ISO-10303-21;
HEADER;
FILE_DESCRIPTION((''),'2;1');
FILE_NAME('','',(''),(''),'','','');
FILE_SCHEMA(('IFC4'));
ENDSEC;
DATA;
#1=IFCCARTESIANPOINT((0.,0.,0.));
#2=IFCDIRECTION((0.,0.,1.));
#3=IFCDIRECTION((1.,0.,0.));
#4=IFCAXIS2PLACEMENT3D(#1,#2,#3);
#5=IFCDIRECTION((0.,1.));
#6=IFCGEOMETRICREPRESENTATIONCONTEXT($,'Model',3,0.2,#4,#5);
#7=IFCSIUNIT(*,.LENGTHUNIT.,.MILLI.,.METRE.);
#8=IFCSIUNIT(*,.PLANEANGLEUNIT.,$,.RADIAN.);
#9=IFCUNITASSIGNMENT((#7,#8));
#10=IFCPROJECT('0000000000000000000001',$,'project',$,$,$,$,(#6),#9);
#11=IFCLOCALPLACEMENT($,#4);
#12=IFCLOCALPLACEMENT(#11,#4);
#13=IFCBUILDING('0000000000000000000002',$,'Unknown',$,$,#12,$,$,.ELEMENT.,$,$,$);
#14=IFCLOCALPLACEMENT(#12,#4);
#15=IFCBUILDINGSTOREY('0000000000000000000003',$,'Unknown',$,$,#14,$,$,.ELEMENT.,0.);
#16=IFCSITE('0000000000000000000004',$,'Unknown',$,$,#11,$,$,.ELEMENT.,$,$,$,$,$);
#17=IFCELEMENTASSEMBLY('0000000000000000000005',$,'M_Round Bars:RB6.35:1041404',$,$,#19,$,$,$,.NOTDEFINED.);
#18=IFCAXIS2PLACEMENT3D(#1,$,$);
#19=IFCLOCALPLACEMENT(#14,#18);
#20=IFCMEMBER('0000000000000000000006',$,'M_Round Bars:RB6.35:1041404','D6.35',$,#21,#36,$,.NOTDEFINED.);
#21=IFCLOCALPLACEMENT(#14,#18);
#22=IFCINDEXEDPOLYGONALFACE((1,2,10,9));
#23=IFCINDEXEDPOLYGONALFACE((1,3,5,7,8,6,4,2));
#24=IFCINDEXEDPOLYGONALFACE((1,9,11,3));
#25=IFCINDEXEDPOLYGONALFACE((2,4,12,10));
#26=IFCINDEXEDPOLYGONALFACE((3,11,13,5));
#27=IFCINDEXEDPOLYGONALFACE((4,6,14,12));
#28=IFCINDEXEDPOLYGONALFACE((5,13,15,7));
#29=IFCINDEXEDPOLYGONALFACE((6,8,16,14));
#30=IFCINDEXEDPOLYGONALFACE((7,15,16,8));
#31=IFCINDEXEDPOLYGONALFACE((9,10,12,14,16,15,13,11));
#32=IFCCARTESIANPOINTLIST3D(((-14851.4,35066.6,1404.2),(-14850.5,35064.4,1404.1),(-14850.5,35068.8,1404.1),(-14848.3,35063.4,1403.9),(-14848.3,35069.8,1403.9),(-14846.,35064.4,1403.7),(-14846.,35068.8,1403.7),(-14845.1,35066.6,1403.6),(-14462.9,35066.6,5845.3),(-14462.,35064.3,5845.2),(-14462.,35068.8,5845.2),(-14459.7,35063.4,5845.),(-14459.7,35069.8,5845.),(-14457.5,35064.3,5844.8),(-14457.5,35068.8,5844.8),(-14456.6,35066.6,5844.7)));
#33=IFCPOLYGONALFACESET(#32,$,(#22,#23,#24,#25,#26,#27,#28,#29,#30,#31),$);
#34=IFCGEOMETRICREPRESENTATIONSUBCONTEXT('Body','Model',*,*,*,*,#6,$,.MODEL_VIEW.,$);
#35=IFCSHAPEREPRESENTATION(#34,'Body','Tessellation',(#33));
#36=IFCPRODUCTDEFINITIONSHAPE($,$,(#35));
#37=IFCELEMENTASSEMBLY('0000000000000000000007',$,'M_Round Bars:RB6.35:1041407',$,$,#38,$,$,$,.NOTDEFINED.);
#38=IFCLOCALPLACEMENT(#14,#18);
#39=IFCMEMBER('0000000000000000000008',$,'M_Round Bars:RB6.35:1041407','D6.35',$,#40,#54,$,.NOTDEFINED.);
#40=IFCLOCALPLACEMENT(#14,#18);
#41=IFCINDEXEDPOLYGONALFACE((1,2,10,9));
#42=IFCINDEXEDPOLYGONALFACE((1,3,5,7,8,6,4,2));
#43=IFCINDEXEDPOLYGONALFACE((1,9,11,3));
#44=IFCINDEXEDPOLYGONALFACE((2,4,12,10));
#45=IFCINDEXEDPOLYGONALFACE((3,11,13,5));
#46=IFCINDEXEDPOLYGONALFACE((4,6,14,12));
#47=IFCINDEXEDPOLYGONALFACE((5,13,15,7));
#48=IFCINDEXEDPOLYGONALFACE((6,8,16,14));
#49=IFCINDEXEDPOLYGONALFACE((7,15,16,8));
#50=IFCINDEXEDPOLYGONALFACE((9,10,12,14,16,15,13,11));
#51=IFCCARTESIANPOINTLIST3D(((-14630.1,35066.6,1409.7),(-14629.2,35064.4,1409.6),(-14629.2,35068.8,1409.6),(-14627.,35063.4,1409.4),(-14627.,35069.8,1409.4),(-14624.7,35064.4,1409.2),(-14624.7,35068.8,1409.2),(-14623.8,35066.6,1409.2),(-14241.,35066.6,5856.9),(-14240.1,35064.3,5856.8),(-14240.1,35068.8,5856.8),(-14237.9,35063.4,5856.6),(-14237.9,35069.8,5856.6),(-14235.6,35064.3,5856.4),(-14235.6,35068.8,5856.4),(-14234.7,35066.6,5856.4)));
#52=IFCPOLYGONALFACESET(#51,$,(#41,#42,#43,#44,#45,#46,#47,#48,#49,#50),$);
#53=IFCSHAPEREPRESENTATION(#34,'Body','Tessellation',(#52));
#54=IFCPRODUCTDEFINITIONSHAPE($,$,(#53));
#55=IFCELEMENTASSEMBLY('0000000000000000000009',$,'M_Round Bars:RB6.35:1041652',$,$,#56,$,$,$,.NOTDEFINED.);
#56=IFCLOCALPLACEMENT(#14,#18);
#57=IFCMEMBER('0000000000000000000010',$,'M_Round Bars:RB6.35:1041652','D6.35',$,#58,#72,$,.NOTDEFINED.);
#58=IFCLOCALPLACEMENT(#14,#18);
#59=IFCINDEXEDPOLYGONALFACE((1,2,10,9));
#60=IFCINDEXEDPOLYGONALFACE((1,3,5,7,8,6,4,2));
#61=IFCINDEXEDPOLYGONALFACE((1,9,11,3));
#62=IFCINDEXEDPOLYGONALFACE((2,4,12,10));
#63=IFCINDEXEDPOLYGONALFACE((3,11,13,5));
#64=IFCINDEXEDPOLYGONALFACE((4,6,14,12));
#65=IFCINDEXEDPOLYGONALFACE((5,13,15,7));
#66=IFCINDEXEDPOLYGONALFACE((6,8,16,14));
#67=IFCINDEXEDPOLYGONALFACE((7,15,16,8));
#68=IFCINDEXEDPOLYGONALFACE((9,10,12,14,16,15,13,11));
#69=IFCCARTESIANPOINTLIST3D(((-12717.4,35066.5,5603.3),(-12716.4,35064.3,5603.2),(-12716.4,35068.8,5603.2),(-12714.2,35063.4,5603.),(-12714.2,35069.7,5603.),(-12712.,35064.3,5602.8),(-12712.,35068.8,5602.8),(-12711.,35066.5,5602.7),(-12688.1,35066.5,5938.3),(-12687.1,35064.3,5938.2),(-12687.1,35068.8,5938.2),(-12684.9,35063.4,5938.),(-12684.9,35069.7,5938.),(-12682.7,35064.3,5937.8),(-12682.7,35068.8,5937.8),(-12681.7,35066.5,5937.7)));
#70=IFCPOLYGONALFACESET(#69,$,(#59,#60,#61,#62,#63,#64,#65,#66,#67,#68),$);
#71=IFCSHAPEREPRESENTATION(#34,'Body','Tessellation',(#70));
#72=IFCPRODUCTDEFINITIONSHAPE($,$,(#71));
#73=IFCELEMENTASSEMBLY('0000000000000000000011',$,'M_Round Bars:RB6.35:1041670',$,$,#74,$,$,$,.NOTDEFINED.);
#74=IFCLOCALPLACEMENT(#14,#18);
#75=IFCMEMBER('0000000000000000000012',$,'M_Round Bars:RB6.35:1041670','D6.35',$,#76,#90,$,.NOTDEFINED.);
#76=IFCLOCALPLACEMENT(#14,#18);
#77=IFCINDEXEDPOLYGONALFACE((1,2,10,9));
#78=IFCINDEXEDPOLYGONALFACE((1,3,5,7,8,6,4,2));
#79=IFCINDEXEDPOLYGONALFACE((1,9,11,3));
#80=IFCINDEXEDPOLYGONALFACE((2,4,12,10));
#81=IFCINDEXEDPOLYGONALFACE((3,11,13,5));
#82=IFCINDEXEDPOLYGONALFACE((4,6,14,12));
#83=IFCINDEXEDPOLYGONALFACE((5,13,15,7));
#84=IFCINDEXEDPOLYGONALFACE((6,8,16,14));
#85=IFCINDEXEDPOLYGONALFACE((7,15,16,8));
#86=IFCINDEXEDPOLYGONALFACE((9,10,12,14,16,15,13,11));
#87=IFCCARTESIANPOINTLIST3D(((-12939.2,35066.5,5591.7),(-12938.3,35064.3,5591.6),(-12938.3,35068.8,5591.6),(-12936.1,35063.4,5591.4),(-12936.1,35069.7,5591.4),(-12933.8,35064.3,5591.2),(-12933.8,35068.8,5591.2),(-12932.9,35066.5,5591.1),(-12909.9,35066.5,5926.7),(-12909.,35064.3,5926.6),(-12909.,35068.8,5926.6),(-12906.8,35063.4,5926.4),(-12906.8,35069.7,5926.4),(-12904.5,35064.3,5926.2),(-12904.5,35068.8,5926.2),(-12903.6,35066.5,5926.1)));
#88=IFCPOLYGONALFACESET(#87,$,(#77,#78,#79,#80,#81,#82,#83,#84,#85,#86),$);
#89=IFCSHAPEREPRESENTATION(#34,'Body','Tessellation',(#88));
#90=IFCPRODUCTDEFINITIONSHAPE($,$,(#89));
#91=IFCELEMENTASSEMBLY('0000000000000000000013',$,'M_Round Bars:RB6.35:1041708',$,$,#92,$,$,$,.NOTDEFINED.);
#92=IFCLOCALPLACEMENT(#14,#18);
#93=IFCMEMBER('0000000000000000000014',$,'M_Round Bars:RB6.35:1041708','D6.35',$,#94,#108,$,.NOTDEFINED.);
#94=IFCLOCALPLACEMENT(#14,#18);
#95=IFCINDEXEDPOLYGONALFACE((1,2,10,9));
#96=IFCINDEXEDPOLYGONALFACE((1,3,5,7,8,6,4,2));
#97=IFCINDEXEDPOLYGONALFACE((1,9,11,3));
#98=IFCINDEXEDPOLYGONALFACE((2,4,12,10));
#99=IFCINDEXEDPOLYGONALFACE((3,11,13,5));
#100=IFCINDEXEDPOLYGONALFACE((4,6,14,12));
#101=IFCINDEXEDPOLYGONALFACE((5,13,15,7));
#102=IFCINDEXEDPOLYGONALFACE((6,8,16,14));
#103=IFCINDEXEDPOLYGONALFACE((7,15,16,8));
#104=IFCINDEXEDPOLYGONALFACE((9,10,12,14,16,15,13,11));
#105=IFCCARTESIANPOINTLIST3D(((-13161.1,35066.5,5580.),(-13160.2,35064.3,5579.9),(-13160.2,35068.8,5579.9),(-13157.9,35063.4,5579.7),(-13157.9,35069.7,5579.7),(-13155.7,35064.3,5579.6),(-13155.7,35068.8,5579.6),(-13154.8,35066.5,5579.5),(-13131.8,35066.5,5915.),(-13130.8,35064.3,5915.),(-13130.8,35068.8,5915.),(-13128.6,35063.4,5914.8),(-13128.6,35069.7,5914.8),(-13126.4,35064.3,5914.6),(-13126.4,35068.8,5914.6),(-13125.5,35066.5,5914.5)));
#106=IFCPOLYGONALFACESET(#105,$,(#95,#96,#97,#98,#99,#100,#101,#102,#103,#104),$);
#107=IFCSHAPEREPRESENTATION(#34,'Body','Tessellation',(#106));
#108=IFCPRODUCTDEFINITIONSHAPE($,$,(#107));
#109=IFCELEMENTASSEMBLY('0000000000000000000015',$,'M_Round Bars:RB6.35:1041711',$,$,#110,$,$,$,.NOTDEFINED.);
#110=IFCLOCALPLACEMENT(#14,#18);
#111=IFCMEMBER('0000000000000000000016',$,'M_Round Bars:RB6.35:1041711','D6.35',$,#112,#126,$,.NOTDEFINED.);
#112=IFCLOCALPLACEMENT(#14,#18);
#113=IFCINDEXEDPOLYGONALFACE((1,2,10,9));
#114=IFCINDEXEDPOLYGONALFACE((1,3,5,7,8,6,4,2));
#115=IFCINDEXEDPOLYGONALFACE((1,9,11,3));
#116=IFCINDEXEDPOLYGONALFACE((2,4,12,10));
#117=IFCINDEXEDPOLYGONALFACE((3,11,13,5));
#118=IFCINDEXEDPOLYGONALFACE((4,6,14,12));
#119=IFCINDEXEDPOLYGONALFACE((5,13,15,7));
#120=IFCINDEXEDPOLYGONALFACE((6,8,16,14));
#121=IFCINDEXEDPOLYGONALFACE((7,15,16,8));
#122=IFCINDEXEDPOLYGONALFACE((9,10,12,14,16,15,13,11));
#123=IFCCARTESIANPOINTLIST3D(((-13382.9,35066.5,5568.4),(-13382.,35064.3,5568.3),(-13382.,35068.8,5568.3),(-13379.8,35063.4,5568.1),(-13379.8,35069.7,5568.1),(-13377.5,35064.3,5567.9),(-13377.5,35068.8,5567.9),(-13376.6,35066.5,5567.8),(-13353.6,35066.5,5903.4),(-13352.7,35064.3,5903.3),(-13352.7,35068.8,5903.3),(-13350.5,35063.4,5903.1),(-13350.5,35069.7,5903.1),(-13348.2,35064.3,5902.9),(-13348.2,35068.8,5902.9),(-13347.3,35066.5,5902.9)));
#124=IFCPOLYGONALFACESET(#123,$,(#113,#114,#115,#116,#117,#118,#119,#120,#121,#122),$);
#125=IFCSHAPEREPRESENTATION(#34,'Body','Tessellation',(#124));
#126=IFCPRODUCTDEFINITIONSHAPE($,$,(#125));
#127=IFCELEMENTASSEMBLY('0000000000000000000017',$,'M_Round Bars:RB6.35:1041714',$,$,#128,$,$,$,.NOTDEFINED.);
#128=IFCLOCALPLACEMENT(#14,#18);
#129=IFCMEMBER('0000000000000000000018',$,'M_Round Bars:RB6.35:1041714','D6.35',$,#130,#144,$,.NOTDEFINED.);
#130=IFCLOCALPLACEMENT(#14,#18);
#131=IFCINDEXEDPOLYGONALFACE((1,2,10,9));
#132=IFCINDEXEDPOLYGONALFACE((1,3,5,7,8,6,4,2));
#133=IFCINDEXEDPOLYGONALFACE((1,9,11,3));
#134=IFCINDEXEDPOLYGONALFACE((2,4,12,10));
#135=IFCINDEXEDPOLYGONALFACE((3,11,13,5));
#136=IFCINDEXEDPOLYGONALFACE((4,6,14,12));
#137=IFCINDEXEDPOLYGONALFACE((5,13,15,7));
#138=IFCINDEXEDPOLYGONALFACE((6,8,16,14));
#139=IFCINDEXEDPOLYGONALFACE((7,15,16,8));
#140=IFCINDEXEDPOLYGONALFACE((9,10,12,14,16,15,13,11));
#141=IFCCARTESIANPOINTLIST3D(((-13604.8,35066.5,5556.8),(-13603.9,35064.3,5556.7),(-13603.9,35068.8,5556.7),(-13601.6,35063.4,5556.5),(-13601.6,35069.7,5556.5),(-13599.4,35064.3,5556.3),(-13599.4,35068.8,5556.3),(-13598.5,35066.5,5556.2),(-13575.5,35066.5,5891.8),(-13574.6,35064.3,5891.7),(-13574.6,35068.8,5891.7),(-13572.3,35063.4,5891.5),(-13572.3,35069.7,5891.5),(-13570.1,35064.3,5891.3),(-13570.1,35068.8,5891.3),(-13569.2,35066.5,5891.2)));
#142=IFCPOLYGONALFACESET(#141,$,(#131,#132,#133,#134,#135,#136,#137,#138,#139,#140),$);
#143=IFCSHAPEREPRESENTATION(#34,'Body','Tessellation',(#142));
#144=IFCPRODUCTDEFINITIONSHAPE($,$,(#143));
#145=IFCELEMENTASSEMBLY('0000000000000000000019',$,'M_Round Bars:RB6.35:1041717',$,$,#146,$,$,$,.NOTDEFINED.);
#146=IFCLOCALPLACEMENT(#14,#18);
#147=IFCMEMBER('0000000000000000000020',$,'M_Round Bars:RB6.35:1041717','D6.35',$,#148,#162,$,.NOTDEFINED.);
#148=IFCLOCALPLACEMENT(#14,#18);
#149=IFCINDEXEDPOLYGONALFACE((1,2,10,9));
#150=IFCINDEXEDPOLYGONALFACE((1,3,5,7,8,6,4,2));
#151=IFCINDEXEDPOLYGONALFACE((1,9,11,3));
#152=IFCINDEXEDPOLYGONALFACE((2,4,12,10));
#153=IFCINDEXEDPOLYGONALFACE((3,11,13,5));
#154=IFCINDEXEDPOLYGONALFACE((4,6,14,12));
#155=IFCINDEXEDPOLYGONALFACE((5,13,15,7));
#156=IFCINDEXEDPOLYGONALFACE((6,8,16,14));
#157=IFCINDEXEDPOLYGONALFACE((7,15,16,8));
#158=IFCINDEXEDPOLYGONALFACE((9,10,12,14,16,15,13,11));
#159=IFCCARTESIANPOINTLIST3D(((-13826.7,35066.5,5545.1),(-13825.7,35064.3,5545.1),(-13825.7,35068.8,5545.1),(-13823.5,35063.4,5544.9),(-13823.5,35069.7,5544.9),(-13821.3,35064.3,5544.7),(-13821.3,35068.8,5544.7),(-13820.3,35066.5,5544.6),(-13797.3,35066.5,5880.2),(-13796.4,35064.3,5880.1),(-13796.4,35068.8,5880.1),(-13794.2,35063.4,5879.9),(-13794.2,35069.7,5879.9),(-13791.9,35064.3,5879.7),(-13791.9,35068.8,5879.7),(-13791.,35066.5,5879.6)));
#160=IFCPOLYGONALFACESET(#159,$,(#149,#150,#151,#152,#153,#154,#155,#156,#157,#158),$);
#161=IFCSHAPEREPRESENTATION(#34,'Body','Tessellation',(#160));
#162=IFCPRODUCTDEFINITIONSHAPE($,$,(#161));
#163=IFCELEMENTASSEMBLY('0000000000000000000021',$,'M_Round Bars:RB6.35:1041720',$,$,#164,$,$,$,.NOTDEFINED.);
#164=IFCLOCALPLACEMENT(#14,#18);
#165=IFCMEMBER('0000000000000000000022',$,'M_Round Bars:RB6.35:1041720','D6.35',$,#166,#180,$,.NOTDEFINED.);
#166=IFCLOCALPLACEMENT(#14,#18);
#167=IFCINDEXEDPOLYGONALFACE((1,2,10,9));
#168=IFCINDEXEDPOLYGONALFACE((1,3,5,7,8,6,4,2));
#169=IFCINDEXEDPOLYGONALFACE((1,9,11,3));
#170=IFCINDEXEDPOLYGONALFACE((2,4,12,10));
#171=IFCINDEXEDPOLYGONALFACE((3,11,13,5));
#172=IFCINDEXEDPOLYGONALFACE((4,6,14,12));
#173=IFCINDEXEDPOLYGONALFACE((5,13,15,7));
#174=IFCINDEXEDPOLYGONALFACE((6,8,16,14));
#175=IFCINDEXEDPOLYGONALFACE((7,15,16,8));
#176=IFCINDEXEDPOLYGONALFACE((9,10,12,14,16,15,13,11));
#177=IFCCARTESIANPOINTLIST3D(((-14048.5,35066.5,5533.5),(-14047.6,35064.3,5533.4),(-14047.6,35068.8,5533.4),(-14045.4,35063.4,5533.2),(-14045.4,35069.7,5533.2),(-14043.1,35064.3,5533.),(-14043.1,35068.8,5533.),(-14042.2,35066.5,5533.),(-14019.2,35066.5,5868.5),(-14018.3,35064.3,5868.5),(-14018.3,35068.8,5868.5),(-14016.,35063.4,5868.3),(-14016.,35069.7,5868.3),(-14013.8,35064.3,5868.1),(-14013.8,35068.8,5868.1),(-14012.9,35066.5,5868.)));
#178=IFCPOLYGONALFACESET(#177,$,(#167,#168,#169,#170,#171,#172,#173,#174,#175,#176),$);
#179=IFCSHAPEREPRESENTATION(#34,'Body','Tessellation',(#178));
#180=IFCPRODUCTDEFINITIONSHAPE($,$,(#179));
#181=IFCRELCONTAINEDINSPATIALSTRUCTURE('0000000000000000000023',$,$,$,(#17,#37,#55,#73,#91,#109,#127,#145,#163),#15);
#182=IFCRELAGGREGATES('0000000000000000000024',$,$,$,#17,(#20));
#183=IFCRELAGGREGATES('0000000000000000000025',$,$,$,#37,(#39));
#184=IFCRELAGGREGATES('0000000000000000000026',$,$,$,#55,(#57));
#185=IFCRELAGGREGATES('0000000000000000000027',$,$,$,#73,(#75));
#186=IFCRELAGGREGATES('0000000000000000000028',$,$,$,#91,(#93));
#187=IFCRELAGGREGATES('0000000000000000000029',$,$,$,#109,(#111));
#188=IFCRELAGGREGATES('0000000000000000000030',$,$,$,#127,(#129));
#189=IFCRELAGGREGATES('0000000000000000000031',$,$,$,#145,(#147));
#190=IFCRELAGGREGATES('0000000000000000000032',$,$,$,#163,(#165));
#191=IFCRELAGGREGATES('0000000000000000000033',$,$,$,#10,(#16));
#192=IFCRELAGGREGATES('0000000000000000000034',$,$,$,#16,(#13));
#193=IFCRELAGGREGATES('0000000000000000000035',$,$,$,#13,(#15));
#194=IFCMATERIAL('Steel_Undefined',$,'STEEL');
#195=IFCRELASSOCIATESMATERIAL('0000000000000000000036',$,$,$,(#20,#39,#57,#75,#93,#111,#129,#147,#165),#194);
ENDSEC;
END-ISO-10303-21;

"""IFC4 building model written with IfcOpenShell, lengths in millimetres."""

from ifc_helpers import new_model, si_unit, direction, frame, origin_with_axes, place, context, subcontext, project, spatial, line, indexed_curve, outline, extrude, material, element, aggregate, save


model = new_model("IFC4")

# Units and contexts
model_context = context("Model", 3, precision=0.2, world=origin_with_axes(), true_north=direction((0.0, 1.0)))
body_context = subcontext(model_context, "Body", "Model", "MODEL_VIEW")
ifc_project = project(units=[si_unit("LENGTHUNIT", "METRE", prefix="MILLI"), si_unit("PLANEANGLEUNIT", "RADIAN")], contexts=[model_context])

# Site, building, storey
site_placement = place(None, origin_with_axes())
site = spatial("IfcSite", under=ifc_project, at=site_placement, Name="Unknown", CompositionType="ELEMENT")
building_placement = place(site_placement, origin_with_axes())
building = spatial("IfcBuilding", under=site, at=building_placement, Name="Unknown", CompositionType="ELEMENT")
storey_placement = place(building_placement, origin_with_axes())
storey = spatial("IfcBuildingStorey", under=building, at=storey_placement, Name="Unknown", CompositionType="ELEMENT", Elevation=0.0)

# Element assemblies, members
assembly_1_placement = place(storey_placement, frame((-14459.7, 35066.6, 5845.0), z_axis=(-0.00002, -1.0, 0.0), x_axis=(-0.087153, 0.000002, -0.996195)))
assembly_1 = element("IfcElementAssembly", 1, at=assembly_1_placement, inside=storey, Name="M_Round Bars:RB6.35:1041404", PredefinedType="NOTDEFINED")
ifc_material_1 = material(Name="Steel_Undefined", Category="STEEL")
member_1_placement = place(assembly_1_placement, origin_with_axes())
member_1 = element("IfcMember", 2, at=member_1_placement, material=ifc_material_1, Name="M_Round Bars:RB6.35:1041404", Description="D6.35", PredefinedType="NOTDEFINED", context=body_context, shape_type="SolidModel", body=[
    extrude(outline(indexed_curve([(3.2, 0.0), (2.2, 2.2), (0.0, 3.2), (-2.2, 2.2), (-3.2, 0.0), (-2.2, -2.2), (0.0, -3.2), (2.2, -2.2)], segments=[line(1, 2, 3, 4, 5, 6, 7, 8, 1)])), frame((0.0, 0.0, 0.0), z_axis=(-1.0, 0.0, 0.0), x_axis=(0.0, 0.0, 1.0)), (0.0, 0.0, -1.0), 4458.1),
])
aggregate(assembly_1, [member_1])
assembly_2_placement = place(storey_placement, frame((-14237.9, 35066.6, 5856.6), z_axis=(-0.00002, -1.0, 0.0), x_axis=(-0.087153, 0.000002, -0.996195)))
assembly_2 = element("IfcElementAssembly", 3, at=assembly_2_placement, inside=storey, Name="M_Round Bars:RB6.35:1041407", PredefinedType="NOTDEFINED")
member_2_placement = place(assembly_2_placement, origin_with_axes())
member_2 = element("IfcMember", 4, at=member_2_placement, material=ifc_material_1, Name="M_Round Bars:RB6.35:1041407", Description="D6.35", PredefinedType="NOTDEFINED", context=body_context, shape_type="SolidModel", body=[
    extrude(outline(indexed_curve([(3.2, 0.0), (2.2, 2.2), (0.0, 3.2), (-2.2, 2.2), (-3.2, 0.0), (-2.2, -2.2), (0.0, -3.2), (2.2, -2.2)], segments=[line(1, 2, 3, 4, 5, 6, 7, 8, 1)])), frame((0.0, 0.0, 0.0), z_axis=(-1.0, 0.0, 0.0), x_axis=(0.0, 0.0, 1.0)), (0.0, 0.0, -1.0), 4464.2),
])
aggregate(assembly_2, [member_2])
assembly_3_placement = place(storey_placement, frame((-12684.9, 35066.5, 5938.0), z_axis=(0.0, -1.0, 0.0), x_axis=(-0.087153, 0.0, -0.996195)))
assembly_3 = element("IfcElementAssembly", 5, at=assembly_3_placement, inside=storey, Name="M_Round Bars:RB6.35:1041652", PredefinedType="NOTDEFINED")
member_3_placement = place(assembly_3_placement, origin_with_axes())
member_3 = element("IfcMember", 6, at=member_3_placement, material=ifc_material_1, Name="M_Round Bars:RB6.35:1041652", Description="D6.35", PredefinedType="NOTDEFINED", context=body_context, shape_type="SolidModel", body=[
    extrude(outline(indexed_curve([(3.2, 0.0), (2.2, 2.2), (0.0, 3.2), (-2.2, 2.2), (-3.2, 0.0), (-2.2, -2.2), (0.0, -3.2), (2.2, -2.2)], segments=[line(1, 2, 3, 4, 5, 6, 7, 8, 1)])), frame((0.0, 0.0, 0.0), z_axis=(-1.0, 0.0, 0.0), x_axis=(0.0, 0.0, 1.0)), (0.0, 0.0, -1.0), 336.3),
])
aggregate(assembly_3, [member_3])
assembly_4_placement = place(storey_placement, frame((-12906.8, 35066.5, 5926.4), z_axis=(0.0, -1.0, 0.0), x_axis=(-0.087153, 0.0, -0.996195)))
assembly_4 = element("IfcElementAssembly", 7, at=assembly_4_placement, inside=storey, Name="M_Round Bars:RB6.35:1041670", PredefinedType="NOTDEFINED")
member_4_placement = place(assembly_4_placement, origin_with_axes())
member_4 = element("IfcMember", 8, at=member_4_placement, material=ifc_material_1, Name="M_Round Bars:RB6.35:1041670", Description="D6.35", PredefinedType="NOTDEFINED", context=body_context, shape_type="SolidModel", body=[
    extrude(outline(indexed_curve([(3.2, 0.0), (2.2, 2.2), (0.0, 3.2), (-2.2, 2.2), (-3.2, 0.0), (-2.2, -2.2), (0.0, -3.2), (2.2, -2.2)], segments=[line(1, 2, 3, 4, 5, 6, 7, 8, 1)])), frame((0.0, 0.0, 0.0), z_axis=(-1.0, 0.0, 0.0), x_axis=(0.0, 0.0, 1.0)), (0.0, 0.0, -1.0), 336.3),
])
aggregate(assembly_4, [member_4])
assembly_5_placement = place(storey_placement, frame((-13128.6, 35066.5, 5914.8), z_axis=(0.0, -1.0, 0.0), x_axis=(-0.087153, 0.0, -0.996195)))
assembly_5 = element("IfcElementAssembly", 9, at=assembly_5_placement, inside=storey, Name="M_Round Bars:RB6.35:1041708", PredefinedType="NOTDEFINED")
member_5_placement = place(assembly_5_placement, origin_with_axes())
member_5 = element("IfcMember", 10, at=member_5_placement, material=ifc_material_1, Name="M_Round Bars:RB6.35:1041708", Description="D6.35", PredefinedType="NOTDEFINED", context=body_context, shape_type="SolidModel", body=[
    extrude(outline(indexed_curve([(3.2, 0.0), (2.2, 2.2), (0.0, 3.2), (-2.2, 2.2), (-3.2, 0.0), (-2.2, -2.2), (0.0, -3.2), (2.2, -2.2)], segments=[line(1, 2, 3, 4, 5, 6, 7, 8, 1)])), frame((0.0, 0.0, 0.0), z_axis=(-1.0, 0.0, 0.0), x_axis=(0.0, 0.0, 1.0)), (0.0, 0.0, -1.0), 336.3),
])
aggregate(assembly_5, [member_5])
assembly_6_placement = place(storey_placement, frame((-13350.5, 35066.5, 5903.1), z_axis=(0.0, -1.0, 0.0), x_axis=(-0.087153, 0.0, -0.996195)))
assembly_6 = element("IfcElementAssembly", 11, at=assembly_6_placement, inside=storey, Name="M_Round Bars:RB6.35:1041711", PredefinedType="NOTDEFINED")
member_6_placement = place(assembly_6_placement, origin_with_axes())
member_6 = element("IfcMember", 12, at=member_6_placement, material=ifc_material_1, Name="M_Round Bars:RB6.35:1041711", Description="D6.35", PredefinedType="NOTDEFINED", context=body_context, shape_type="SolidModel", body=[
    extrude(outline(indexed_curve([(3.2, 0.0), (2.2, 2.2), (0.0, 3.2), (-2.2, 2.2), (-3.2, 0.0), (-2.2, -2.2), (0.0, -3.2), (2.2, -2.2)], segments=[line(1, 2, 3, 4, 5, 6, 7, 8, 1)])), frame((0.0, 0.0, 0.0), z_axis=(-1.0, 0.0, 0.0), x_axis=(0.0, 0.0, 1.0)), (0.0, 0.0, -1.0), 336.3),
])
aggregate(assembly_6, [member_6])
assembly_7_placement = place(storey_placement, frame((-13572.3, 35066.5, 5891.5), z_axis=(0.0, -1.0, 0.0), x_axis=(-0.087153, 0.0, -0.996195)))
assembly_7 = element("IfcElementAssembly", 13, at=assembly_7_placement, inside=storey, Name="M_Round Bars:RB6.35:1041714", PredefinedType="NOTDEFINED")
member_7_placement = place(assembly_7_placement, origin_with_axes())
member_7 = element("IfcMember", 14, at=member_7_placement, material=ifc_material_1, Name="M_Round Bars:RB6.35:1041714", Description="D6.35", PredefinedType="NOTDEFINED", context=body_context, shape_type="SolidModel", body=[
    extrude(outline(indexed_curve([(3.2, 0.0), (2.2, 2.2), (0.0, 3.2), (-2.2, 2.2), (-3.2, 0.0), (-2.2, -2.2), (0.0, -3.2), (2.2, -2.2)], segments=[line(1, 2, 3, 4, 5, 6, 7, 8, 1)])), frame((0.0, 0.0, 0.0), z_axis=(-1.0, 0.0, 0.0), x_axis=(0.0, 0.0, 1.0)), (0.0, 0.0, -1.0), 336.3),
])
aggregate(assembly_7, [member_7])
assembly_8_placement = place(storey_placement, frame((-13794.2, 35066.5, 5879.9), z_axis=(0.0, -1.0, 0.0), x_axis=(-0.087153, 0.0, -0.996195)))
assembly_8 = element("IfcElementAssembly", 15, at=assembly_8_placement, inside=storey, Name="M_Round Bars:RB6.35:1041717", PredefinedType="NOTDEFINED")
member_8_placement = place(assembly_8_placement, origin_with_axes())
member_8 = element("IfcMember", 16, at=member_8_placement, material=ifc_material_1, Name="M_Round Bars:RB6.35:1041717", Description="D6.35", PredefinedType="NOTDEFINED", context=body_context, shape_type="SolidModel", body=[
    extrude(outline(indexed_curve([(3.2, 0.0), (2.2, 2.2), (0.0, 3.2), (-2.2, 2.2), (-3.2, 0.0), (-2.2, -2.2), (0.0, -3.2), (2.2, -2.2)], segments=[line(1, 2, 3, 4, 5, 6, 7, 8, 1)])), frame((0.0, 0.0, 0.0), z_axis=(-1.0, 0.0, 0.0), x_axis=(0.0, 0.0, 1.0)), (0.0, 0.0, -1.0), 336.3),
])
aggregate(assembly_8, [member_8])
assembly_9_placement = place(storey_placement, frame((-14016.0, 35066.5, 5868.3), z_axis=(0.0, -1.0, 0.0), x_axis=(-0.087153, 0.0, -0.996195)))
assembly_9 = element("IfcElementAssembly", 17, at=assembly_9_placement, inside=storey, Name="M_Round Bars:RB6.35:1041720", PredefinedType="NOTDEFINED")
member_9_placement = place(assembly_9_placement, origin_with_axes())
member_9 = element("IfcMember", 18, at=member_9_placement, material=ifc_material_1, Name="M_Round Bars:RB6.35:1041720", Description="D6.35", PredefinedType="NOTDEFINED", context=body_context, shape_type="SolidModel", body=[
    extrude(outline(indexed_curve([(3.2, 0.0), (2.2, 2.2), (0.0, 3.2), (-2.2, 2.2), (-3.2, 0.0), (-2.2, -2.2), (0.0, -3.2), (2.2, -2.2)], segments=[line(1, 2, 3, 4, 5, 6, 7, 8, 1)])), frame((0.0, 0.0, 0.0), z_axis=(-1.0, 0.0, 0.0), x_axis=(0.0, 0.0, 1.0)), (0.0, 0.0, -1.0), 336.3),
])
aggregate(assembly_9, [member_9])

save(model, "model.ifc")
